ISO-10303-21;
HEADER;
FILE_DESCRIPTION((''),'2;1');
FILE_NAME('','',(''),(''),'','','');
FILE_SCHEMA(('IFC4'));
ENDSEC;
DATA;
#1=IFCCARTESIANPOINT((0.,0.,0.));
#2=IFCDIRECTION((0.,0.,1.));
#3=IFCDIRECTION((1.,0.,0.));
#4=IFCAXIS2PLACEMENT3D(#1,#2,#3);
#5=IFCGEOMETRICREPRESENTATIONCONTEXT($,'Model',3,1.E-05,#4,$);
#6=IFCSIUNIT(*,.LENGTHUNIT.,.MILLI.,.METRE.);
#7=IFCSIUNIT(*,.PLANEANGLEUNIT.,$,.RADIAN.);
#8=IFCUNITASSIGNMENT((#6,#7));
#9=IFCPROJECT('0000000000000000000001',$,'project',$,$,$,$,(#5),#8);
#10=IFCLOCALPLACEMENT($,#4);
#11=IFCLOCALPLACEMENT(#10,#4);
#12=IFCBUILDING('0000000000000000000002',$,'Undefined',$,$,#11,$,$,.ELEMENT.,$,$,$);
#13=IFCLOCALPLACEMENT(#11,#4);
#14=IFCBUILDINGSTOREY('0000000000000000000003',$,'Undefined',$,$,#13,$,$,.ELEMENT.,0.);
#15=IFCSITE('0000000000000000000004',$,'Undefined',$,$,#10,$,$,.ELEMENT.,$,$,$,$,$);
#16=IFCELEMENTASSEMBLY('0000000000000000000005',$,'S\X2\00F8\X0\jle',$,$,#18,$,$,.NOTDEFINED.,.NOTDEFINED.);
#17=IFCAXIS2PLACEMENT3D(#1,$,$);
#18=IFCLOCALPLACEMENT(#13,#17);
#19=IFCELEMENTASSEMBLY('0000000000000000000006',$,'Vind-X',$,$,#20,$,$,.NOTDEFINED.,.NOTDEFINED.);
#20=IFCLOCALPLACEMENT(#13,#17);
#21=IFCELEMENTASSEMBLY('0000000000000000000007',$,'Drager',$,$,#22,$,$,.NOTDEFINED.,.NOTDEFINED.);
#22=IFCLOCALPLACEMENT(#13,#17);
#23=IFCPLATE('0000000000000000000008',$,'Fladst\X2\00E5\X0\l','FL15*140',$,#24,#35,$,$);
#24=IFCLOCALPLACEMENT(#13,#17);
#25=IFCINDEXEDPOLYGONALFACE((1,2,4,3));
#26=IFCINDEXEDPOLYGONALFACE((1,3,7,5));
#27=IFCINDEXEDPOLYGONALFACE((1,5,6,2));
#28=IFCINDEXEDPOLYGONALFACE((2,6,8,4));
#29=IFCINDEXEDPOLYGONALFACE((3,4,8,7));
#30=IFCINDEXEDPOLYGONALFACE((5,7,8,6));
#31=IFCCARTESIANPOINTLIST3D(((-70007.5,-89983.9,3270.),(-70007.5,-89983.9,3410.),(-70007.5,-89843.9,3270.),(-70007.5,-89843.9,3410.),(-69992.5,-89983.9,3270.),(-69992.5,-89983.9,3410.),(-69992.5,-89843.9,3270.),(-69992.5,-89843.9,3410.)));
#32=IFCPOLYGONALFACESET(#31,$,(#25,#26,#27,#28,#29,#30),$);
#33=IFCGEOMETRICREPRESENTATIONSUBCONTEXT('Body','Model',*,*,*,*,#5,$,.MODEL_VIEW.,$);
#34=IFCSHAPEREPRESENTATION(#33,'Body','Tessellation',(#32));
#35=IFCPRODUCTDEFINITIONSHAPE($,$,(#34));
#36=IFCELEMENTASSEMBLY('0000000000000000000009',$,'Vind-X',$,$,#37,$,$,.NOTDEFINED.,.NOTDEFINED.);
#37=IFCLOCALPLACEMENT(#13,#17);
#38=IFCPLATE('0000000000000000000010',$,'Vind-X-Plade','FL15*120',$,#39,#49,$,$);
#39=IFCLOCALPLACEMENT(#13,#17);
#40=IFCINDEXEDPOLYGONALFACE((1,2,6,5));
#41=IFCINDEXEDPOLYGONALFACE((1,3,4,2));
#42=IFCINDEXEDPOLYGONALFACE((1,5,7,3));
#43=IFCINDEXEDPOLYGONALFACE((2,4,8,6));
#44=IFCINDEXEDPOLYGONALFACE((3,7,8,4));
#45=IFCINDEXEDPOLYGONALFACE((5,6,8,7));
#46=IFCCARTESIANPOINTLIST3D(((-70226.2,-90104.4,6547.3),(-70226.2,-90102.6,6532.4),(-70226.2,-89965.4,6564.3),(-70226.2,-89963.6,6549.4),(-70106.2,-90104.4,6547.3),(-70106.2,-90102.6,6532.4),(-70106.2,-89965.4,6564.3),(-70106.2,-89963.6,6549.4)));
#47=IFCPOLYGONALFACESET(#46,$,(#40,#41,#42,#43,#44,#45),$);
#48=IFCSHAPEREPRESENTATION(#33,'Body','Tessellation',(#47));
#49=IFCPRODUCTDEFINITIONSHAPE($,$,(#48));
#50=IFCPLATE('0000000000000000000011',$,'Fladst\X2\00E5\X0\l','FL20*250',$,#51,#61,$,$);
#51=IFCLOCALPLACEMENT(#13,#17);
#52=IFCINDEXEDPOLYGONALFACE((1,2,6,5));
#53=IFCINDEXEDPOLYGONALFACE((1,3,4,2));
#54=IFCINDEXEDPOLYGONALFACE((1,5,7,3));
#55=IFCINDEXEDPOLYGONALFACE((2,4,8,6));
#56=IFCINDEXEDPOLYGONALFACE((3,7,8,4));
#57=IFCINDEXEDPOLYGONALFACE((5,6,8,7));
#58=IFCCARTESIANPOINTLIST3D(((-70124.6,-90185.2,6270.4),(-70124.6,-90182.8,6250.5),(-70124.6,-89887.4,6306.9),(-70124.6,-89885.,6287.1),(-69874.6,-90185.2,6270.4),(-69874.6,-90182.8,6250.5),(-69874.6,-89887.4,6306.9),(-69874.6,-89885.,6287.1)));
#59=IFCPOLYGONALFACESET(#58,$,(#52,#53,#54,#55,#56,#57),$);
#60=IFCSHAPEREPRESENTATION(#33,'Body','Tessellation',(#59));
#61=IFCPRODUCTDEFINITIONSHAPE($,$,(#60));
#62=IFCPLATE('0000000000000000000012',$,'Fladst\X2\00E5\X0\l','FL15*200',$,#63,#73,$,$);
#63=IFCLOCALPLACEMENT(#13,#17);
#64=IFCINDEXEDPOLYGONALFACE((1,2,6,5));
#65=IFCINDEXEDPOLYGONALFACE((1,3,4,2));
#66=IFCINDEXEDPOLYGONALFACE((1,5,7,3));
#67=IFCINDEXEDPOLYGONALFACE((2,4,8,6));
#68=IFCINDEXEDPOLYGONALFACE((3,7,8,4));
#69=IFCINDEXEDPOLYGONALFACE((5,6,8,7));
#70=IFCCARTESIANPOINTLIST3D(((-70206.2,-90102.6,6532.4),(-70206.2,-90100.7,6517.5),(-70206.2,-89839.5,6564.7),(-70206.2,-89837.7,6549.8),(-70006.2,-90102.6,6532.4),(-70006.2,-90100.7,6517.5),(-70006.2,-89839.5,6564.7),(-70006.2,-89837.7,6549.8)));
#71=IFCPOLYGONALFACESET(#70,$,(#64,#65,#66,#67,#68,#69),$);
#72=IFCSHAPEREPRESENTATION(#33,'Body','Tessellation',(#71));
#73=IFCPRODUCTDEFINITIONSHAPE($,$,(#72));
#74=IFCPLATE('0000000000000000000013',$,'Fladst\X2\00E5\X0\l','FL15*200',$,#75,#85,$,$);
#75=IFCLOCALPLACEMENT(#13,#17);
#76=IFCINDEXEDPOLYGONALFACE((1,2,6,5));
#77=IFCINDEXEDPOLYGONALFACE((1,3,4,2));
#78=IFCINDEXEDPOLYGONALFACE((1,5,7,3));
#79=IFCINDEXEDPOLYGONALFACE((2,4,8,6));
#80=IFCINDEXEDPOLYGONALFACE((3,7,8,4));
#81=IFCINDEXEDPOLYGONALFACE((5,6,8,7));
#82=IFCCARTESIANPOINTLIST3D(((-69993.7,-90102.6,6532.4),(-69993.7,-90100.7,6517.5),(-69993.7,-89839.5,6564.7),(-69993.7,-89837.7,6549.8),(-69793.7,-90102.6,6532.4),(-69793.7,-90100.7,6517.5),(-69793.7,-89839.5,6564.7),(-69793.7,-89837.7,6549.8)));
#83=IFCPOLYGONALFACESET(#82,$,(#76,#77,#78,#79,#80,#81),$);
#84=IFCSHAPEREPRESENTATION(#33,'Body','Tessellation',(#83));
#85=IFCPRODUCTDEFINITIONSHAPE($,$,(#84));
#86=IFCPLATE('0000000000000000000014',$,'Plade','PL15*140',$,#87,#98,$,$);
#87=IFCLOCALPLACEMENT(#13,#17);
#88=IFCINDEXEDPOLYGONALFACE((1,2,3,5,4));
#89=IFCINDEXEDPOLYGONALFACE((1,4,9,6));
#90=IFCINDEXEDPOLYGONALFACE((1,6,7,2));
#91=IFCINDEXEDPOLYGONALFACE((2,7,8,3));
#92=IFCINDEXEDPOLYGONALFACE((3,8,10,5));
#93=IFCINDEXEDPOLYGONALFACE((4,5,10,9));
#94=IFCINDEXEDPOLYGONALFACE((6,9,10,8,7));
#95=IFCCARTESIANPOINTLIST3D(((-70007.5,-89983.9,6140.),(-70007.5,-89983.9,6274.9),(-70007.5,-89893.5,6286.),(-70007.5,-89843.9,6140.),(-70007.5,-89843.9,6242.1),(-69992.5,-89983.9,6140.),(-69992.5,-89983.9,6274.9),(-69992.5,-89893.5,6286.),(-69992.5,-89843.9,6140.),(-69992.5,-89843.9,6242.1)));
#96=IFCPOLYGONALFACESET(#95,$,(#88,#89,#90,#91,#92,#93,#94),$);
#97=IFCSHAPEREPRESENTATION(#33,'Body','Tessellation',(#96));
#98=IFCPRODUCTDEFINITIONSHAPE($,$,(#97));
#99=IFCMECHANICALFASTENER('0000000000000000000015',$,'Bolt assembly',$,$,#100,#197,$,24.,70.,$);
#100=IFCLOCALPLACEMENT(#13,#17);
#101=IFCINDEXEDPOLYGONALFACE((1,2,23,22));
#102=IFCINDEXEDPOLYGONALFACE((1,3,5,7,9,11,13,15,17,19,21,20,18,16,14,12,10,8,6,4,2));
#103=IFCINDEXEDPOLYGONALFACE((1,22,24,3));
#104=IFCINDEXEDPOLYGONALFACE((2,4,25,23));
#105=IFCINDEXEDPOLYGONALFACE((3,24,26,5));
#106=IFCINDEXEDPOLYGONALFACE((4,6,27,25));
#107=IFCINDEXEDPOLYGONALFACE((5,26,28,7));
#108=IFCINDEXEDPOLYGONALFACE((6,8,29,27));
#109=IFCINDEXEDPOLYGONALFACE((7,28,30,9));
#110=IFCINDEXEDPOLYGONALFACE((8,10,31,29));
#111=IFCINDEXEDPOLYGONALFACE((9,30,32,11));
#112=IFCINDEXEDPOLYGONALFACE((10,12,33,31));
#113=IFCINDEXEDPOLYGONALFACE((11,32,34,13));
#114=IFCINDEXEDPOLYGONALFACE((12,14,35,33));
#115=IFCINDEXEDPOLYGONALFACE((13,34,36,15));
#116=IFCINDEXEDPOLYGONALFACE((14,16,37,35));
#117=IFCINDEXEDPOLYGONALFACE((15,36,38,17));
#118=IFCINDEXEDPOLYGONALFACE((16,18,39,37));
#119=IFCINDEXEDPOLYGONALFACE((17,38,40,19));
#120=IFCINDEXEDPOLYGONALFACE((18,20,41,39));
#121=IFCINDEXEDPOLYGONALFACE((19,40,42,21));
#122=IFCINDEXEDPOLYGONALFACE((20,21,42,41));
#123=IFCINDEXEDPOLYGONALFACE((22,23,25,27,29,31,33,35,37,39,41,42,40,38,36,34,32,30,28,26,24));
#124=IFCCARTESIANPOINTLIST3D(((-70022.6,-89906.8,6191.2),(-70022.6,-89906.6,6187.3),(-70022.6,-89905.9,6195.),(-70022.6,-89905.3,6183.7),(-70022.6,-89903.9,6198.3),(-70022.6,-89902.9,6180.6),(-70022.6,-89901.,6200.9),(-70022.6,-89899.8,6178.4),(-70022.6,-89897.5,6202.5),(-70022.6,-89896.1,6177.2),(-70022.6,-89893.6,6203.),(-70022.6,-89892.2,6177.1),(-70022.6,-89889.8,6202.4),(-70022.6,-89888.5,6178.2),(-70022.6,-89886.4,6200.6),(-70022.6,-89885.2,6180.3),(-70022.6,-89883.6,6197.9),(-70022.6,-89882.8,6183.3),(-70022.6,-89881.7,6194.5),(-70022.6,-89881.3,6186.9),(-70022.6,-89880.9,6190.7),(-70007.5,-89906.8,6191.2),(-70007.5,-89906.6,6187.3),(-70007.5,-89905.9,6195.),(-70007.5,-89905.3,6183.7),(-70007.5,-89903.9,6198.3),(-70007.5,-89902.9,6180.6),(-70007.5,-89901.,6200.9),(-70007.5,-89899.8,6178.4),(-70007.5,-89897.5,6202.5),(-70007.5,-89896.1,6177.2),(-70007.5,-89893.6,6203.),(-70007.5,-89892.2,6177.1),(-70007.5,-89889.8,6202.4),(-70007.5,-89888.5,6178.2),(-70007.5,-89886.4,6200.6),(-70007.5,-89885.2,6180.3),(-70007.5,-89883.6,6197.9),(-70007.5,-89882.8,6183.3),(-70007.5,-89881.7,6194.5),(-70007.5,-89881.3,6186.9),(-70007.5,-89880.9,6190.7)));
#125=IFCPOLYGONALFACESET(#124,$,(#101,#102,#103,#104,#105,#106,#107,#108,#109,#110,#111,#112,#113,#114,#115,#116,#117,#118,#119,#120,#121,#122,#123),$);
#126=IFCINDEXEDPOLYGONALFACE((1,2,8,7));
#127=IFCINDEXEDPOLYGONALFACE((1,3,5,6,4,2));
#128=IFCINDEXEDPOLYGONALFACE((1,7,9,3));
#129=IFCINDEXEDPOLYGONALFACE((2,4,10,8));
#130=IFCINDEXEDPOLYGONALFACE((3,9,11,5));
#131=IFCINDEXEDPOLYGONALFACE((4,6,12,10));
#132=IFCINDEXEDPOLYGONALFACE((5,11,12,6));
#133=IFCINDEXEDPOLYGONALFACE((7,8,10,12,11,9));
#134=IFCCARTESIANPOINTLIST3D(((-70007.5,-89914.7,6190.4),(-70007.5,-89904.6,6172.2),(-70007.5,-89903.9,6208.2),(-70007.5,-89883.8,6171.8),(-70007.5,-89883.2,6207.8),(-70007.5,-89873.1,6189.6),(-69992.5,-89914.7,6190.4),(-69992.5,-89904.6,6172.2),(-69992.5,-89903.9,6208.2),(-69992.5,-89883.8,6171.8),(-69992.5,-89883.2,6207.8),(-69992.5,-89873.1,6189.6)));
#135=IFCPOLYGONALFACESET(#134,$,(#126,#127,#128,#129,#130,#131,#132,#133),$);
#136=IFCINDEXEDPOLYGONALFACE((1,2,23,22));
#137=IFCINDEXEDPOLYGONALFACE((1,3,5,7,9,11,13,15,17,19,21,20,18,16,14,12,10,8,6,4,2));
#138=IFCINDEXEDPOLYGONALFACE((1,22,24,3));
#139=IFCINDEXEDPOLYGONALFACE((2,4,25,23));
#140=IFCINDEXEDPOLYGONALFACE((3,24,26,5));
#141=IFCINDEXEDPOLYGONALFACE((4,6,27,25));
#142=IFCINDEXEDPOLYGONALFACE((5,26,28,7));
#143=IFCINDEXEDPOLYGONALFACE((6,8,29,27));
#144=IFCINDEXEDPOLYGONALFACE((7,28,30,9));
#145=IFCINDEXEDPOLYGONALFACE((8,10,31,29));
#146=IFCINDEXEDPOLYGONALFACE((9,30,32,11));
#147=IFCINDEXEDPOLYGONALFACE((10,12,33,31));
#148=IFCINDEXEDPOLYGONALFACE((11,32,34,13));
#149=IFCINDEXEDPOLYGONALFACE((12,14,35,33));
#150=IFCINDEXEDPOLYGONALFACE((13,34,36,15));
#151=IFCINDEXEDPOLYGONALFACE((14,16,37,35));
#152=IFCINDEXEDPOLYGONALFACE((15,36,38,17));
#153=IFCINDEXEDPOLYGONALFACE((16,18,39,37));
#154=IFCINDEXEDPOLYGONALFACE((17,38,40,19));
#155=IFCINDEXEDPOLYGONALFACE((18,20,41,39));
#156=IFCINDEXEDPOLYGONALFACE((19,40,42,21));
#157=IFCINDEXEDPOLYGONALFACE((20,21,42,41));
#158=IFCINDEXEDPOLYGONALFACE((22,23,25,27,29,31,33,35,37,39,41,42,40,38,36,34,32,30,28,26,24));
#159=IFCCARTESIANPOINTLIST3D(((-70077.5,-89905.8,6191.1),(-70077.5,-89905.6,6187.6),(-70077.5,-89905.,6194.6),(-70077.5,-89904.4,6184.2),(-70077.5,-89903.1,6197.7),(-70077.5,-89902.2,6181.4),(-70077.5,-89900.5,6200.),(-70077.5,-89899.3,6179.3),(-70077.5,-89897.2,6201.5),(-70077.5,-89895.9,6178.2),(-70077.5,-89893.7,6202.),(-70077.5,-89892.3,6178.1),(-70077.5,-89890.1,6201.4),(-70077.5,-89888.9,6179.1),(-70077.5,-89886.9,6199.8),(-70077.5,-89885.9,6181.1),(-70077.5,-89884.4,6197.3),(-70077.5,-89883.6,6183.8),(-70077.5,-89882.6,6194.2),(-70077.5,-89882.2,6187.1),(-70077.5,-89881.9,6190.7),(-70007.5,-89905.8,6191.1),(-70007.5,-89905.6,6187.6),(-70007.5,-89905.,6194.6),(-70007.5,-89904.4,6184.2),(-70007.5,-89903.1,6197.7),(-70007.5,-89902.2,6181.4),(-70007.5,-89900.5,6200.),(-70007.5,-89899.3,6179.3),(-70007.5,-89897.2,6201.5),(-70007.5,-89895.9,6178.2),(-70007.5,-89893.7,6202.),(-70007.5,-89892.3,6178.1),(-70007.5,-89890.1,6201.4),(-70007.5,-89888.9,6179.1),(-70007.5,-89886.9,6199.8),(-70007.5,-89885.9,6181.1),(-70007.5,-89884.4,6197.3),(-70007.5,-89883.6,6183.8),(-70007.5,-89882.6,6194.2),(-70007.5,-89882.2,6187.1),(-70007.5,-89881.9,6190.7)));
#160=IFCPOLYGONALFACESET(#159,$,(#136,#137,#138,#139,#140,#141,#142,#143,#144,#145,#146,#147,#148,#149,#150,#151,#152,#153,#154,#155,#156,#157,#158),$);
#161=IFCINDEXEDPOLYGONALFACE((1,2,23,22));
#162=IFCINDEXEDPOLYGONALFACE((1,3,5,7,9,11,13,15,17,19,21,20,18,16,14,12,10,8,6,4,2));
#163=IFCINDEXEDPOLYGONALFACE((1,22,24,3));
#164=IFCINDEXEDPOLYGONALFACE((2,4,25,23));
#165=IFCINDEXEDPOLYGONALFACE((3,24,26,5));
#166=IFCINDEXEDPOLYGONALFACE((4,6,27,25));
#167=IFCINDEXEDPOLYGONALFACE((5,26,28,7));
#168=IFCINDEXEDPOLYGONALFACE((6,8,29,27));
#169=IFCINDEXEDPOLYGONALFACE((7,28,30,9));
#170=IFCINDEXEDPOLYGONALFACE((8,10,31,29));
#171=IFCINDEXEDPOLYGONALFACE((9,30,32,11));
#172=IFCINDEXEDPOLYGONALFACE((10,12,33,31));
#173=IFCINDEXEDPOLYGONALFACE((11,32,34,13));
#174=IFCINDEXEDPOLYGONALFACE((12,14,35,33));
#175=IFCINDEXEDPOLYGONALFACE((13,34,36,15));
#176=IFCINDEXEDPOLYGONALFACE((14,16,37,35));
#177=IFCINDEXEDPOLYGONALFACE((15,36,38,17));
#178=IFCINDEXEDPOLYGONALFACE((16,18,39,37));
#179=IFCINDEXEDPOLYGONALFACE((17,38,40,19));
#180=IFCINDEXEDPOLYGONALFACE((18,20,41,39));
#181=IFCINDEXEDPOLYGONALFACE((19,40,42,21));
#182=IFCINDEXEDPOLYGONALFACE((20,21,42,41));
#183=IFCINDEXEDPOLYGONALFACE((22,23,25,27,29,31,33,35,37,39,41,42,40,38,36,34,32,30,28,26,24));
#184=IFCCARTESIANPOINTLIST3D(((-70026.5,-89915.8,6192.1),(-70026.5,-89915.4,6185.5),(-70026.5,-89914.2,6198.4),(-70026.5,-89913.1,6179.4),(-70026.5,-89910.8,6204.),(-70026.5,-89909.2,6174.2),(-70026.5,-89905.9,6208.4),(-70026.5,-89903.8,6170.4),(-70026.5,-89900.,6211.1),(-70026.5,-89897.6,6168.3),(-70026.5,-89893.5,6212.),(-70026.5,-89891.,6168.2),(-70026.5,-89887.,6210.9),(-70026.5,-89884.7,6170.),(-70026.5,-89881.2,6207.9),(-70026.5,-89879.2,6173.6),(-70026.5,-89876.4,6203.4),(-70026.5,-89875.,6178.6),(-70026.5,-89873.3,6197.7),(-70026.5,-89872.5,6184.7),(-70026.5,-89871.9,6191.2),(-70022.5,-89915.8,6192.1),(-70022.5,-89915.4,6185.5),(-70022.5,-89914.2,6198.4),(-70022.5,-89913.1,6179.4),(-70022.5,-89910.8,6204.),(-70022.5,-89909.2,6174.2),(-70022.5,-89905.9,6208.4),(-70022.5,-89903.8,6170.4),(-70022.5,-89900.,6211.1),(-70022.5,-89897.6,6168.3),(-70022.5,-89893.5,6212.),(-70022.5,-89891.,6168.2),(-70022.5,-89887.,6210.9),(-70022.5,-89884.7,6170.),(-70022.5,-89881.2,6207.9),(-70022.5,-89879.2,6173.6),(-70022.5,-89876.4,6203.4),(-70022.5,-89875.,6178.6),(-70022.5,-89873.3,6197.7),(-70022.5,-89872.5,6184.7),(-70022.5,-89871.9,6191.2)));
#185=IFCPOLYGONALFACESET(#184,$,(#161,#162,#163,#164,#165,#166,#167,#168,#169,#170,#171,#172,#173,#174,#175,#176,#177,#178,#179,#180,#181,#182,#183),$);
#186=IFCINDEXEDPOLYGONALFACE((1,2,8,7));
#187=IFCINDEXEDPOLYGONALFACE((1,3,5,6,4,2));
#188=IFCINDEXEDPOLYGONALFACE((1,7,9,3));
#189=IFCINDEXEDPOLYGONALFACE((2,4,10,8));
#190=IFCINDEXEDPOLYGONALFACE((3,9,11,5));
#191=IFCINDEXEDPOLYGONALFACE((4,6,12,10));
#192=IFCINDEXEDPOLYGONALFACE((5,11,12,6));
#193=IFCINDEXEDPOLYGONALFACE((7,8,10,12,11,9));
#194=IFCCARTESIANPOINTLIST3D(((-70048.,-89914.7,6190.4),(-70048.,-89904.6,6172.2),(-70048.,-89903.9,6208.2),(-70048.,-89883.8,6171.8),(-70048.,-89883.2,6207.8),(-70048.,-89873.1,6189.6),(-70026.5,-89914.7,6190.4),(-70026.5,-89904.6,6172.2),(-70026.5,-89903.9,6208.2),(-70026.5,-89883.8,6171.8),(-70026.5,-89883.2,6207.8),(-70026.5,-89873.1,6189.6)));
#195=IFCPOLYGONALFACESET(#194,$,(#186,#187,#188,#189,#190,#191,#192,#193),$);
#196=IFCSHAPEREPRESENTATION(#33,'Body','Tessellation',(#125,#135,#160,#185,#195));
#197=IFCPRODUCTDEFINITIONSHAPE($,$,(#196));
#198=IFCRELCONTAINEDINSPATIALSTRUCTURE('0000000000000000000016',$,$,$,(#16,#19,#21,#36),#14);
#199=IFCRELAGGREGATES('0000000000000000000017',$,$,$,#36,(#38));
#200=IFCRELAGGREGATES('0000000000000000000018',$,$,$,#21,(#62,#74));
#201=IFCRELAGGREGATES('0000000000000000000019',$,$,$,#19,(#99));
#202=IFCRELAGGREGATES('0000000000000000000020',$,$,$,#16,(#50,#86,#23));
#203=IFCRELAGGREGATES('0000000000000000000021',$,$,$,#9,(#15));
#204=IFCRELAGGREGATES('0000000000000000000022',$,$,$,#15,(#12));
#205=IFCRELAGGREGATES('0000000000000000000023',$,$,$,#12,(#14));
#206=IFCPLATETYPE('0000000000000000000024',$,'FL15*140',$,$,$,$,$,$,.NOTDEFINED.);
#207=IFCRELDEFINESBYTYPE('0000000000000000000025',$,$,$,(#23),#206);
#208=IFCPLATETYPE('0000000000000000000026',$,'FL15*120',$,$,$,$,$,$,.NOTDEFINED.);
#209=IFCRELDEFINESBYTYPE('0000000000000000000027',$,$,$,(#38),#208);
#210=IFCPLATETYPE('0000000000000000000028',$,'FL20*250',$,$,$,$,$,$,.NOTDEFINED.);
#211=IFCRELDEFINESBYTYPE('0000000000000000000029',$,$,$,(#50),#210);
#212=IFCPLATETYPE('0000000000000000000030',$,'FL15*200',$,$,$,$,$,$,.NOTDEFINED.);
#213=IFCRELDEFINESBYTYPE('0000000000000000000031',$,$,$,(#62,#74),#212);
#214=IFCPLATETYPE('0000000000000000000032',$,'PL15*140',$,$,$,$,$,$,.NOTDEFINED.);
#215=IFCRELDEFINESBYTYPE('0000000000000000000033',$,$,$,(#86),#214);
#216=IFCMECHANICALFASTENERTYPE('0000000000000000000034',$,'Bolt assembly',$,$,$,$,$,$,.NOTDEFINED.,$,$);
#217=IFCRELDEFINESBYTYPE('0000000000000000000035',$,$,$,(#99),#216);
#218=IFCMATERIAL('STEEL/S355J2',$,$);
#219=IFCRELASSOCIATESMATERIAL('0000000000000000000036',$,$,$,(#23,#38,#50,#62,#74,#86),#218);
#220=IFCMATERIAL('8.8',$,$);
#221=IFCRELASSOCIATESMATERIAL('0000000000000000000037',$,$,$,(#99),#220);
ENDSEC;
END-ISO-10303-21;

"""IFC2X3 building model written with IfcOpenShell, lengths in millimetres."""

from ifc_helpers import new_model, si_unit, frame, origin_with_axes, origin_2d_with_axis, place, context, subcontext, project, spatial, polyline, circle, outline, extrude, source, transform, mapped, material, type_object, element, aggregate, save


model = new_model("IFC2X3")

# Units and contexts
model_context = context("Model", 3, precision=1e-05, world=origin_with_axes())
body_context = subcontext(model_context, "Body", "Model", "MODEL_VIEW")
ifc_project = project(units=[si_unit("LENGTHUNIT", "METRE", prefix="MILLI"), si_unit("PLANEANGLEUNIT", "RADIAN")], contexts=[model_context])

# Site, building, storey
site_placement = place(None, origin_with_axes())
site = spatial("IfcSite", under=ifc_project, at=site_placement, Name="Undefined", CompositionType="ELEMENT")
building_placement = place(site_placement, origin_with_axes())
building = spatial("IfcBuilding", under=site, at=building_placement, Name="Undefined", CompositionType="ELEMENT")
storey_placement = place(building_placement, origin_with_axes())
storey = spatial("IfcBuildingStorey", under=building, at=storey_placement, Name="Undefined", CompositionType="ELEMENT", Elevation=0.0)

# Element assembly
assembly_1_placement = place(storey_placement, origin_with_axes())
assembly_1 = element("IfcElementAssembly", 1, at=assembly_1_placement, inside=storey, Name="Søjle", AssemblyPlace="NOTDEFINED", PredefinedType="NOTDEFINED")

# Shared definitions
ifc_material_1 = material(Name="STEEL/S355J2")

# Element assembly
assembly_2_placement = place(storey_placement, origin_with_axes())
assembly_2 = element("IfcElementAssembly", 2, at=assembly_2_placement, inside=storey, Name="Vind-X", AssemblyPlace="NOTDEFINED", PredefinedType="NOTDEFINED")

# Element assembly
assembly_3_placement = place(storey_placement, origin_with_axes())
assembly_3 = element("IfcElementAssembly", 3, at=assembly_3_placement, inside=storey, Name="Drager", AssemblyPlace="NOTDEFINED", PredefinedType="NOTDEFINED")
plate_type_1 = type_object("IfcPlateType", Name="FL15*140", PredefinedType="NOTDEFINED")

# Plate
plate_1_placement = place(assembly_1_placement, frame((-70000.0, -89843.9, 3270.0), z_axis=(-1.0, -0.000008, 0.0), x_axis=(0.000008, -1.0, 0.0)))
plate_1 = element("IfcPlate", 4, at=plate_1_placement, type_object=plate_type_1, material=ifc_material_1, Name="Fladstål", Description="FL15*140", context=body_context, shape_type="SweptSolid", body=[
    extrude(outline(polyline([(0.0, 0.0), (140.0, 0.0), (140.0, 140.0), (0.0, 140.0), (0.0, 0.0)])), frame((0.0, 0.0, -7.5), z_axis=(0.0, 0.0, 1.0), x_axis=(1.0, 0.0, 0.0)), (0.0, 0.0, 1.0), 15.0),
])

# Element assembly, plate
assembly_4_placement = place(storey_placement, origin_with_axes())
assembly_4 = element("IfcElementAssembly", 5, at=assembly_4_placement, inside=storey, Name="Vind-X", AssemblyPlace="NOTDEFINED", PredefinedType="NOTDEFINED")
plate_type_2 = type_object("IfcPlateType", Name="FL15*120", PredefinedType="NOTDEFINED")
plate_2_placement = place(assembly_4_placement, frame((-70106.2, -90034.0, 6548.4), z_axis=(0.0, 0.121869, -0.992546), x_axis=(-1.0, 0.0, 0.0)))
plate_2 = element("IfcPlate", 6, at=plate_2_placement, type_object=plate_type_2, material=ifc_material_1, Name="Vind-X-Plade", Description="FL15*120", context=body_context, shape_type="SweptSolid", body=[
    extrude(outline(polyline([(0.0, -70.0), (0.0, 70.0), (120.0, 70.0), (120.0, -70.0), (0.0, -70.0)])), frame((0.0, 0.0, -7.5), z_axis=(0.0, 0.0, 1.0), x_axis=(1.0, 0.0, 0.0)), (0.0, 0.0, 1.0), 15.0),
])
aggregate(assembly_4, [plate_2])

# Plates
plate_type_3 = type_object("IfcPlateType", Name="FL20*250", PredefinedType="NOTDEFINED")
plate_3_placement = place(assembly_1_placement, frame((-69999.6, -90184.0, 6260.4), z_axis=(0.0, 0.121869, -0.992546), x_axis=(0.0, 0.992546, 0.121869)))
plate_3 = element("IfcPlate", 7, at=plate_3_placement, type_object=plate_type_3, material=ifc_material_1, Name="Fladstål", Description="FL20*250", context=body_context, shape_type="SweptSolid", body=[
    extrude(outline(polyline([(0.0, -125.0), (0.0, 125.0), (300.0, 125.0), (300.0, -125.0), (0.0, -125.0)])), frame((0.0, 0.0, -10.0), z_axis=(0.0, 0.0, 1.0), x_axis=(1.0, 0.0, 0.0)), (0.0, 0.0, 1.0), 20.0),
])
plate_type_4 = type_object("IfcPlateType", Name="FL15*200", PredefinedType="NOTDEFINED")
plate_4_placement = place(assembly_3_placement, frame((-70006.2, -90101.6, 6524.9), z_axis=(0.0, -0.121869, 0.992546), x_axis=(0.0, 0.992546, 0.121869)))
plate_4 = element("IfcPlate", 8, at=plate_4_placement, type_object=plate_type_4, material=ifc_material_1, Name="Fladstål", Description="FL15*200", context=body_context, shape_type="SweptSolid", body=[
    extrude(outline(polyline([(0.0, 0.0), (265.0, 0.0), (265.0, 200.0), (0.0, 200.0), (0.0, 0.0)])), frame((0.0, 0.0, -7.5), z_axis=(0.0, 0.0, 1.0), x_axis=(1.0, 0.0, 0.0)), (0.0, 0.0, 1.0), 15.0),
])
plate_5_placement = place(assembly_3_placement, frame((-69993.7, -89838.6, 6557.2), z_axis=(0.0, -0.121869, 0.992546), x_axis=(0.0, -0.992546, -0.121869)))
plate_5 = element("IfcPlate", 9, at=plate_5_placement, type_object=plate_type_4, material=ifc_material_1, Name="Fladstål", Description="FL15*200", context=body_context, shape_type="SweptSolid", body=[
    extrude(outline(polyline([(0.0, 0.0), (265.0, 0.0), (265.0, 200.0), (0.0, 200.0), (0.0, 0.0)])), frame((0.0, 0.0, -7.5), z_axis=(0.0, 0.0, 1.0), x_axis=(1.0, 0.0, 0.0)), (0.0, 0.0, 1.0), 15.0),
])
aggregate(assembly_3, [plate_4, plate_5])
plate_type_5 = type_object("IfcPlateType", Name="PL15*140", PredefinedType="NOTDEFINED")
plate_6_placement = place(assembly_1_placement, frame((-70000.0, -89843.9, 6140.0), z_axis=(-1.0, -0.000008, 0.0), x_axis=(0.000008, -1.0, 0.0)))
plate_6 = element("IfcPlate", 10, at=plate_6_placement, type_object=plate_type_5, material=ifc_material_1, Name="Plade", Description="PL15*140", context=body_context, shape_type="SweptSolid", body=[
    extrude(outline(polyline([(0.0, 0.0), (140.0, 0.0), (140.0, 134.9), (49.6, 146.0), (0.0, 102.1), (0.0, 0.0)])), frame((0.0, 0.0, -7.5), z_axis=(0.0, 0.0, 1.0), x_axis=(1.0, 0.0, 0.0)), (0.0, 0.0, 1.0), 15.0),
])

# Mechanical fastener
ifc_material_2 = material(Name="8.8")
mechanical_fastener_type = type_object("IfcMechanicalFastenerType", Name="Bolt assembly")
shared_shape_1 = source(origin_with_axes(), body_context, "Body", "SweptSolid", [
    extrude(circle(Radius=13.0, at=origin_2d_with_axis()), frame((0.0, 0.0, 0.0), z_axis=(0.0, 1.0, 0.0), x_axis=(1.0, 0.0, 0.0)), (0.0, 0.0, 1.0), 15.1),
    extrude(outline(polyline([(18.0, -10.4), (18.0, 10.4), (0.0, 20.8), (-18.0, 10.4), (-18.0, -10.4), (0.0, -20.8), (18.0, -10.4)])), frame((0.0, -15.0, 0.0), z_axis=(0.0, 1.0, 0.0), x_axis=(1.0, 0.0, 0.0)), (0.0, 0.0, 1.0), 15.0),
    extrude(circle(Radius=12.0, at=origin_2d_with_axis()), frame((0.0, 0.0, 0.0), z_axis=(0.0, 1.0, 0.0), x_axis=(1.0, 0.0, 0.0)), (0.0, 0.0, 1.0), 70.0),
    extrude(circle(Radius=22.0, at=origin_2d_with_axis()), frame((0.0, 15.0, 0.0), z_axis=(0.0, 1.0, 0.0), x_axis=(1.0, 0.0, 0.0)), (0.0, 0.0, 1.0), 4.0),
    extrude(outline(polyline([(18.0, -10.4), (18.0, 10.4), (0.0, 20.8), (-18.0, 10.4), (-18.0, -10.4), (0.0, -20.8), (18.0, -10.4)])), frame((0.0, 19.0, 0.0), z_axis=(0.0, 1.0, 0.0), x_axis=(1.0, 0.0, 0.0)), (0.0, 0.0, 1.0), 21.5),
])
mechanical_fastener_1_placement = place(assembly_2_placement, frame((-70007.5, -89893.9, 6190.0), z_axis=(0.0, 0.516247, 0.85644), x_axis=(0.0, 0.85644, -0.516247)))
mechanical_fastener_1 = element("IfcMechanicalFastener", 11, at=mechanical_fastener_1_placement, type_object=mechanical_fastener_type, material=ifc_material_2, Name="Bolt assembly", NominalDiameter=24.0, NominalLength=70.0, context=body_context, shape_type="MappedRepresentation", body=[
    mapped(shared_shape_1, transform((0.0, 0.0, 0.0))),
])
aggregate(assembly_2, [mechanical_fastener_1])
aggregate(assembly_1, [plate_3, plate_6, plate_1])

save(model, "model.ifc")
